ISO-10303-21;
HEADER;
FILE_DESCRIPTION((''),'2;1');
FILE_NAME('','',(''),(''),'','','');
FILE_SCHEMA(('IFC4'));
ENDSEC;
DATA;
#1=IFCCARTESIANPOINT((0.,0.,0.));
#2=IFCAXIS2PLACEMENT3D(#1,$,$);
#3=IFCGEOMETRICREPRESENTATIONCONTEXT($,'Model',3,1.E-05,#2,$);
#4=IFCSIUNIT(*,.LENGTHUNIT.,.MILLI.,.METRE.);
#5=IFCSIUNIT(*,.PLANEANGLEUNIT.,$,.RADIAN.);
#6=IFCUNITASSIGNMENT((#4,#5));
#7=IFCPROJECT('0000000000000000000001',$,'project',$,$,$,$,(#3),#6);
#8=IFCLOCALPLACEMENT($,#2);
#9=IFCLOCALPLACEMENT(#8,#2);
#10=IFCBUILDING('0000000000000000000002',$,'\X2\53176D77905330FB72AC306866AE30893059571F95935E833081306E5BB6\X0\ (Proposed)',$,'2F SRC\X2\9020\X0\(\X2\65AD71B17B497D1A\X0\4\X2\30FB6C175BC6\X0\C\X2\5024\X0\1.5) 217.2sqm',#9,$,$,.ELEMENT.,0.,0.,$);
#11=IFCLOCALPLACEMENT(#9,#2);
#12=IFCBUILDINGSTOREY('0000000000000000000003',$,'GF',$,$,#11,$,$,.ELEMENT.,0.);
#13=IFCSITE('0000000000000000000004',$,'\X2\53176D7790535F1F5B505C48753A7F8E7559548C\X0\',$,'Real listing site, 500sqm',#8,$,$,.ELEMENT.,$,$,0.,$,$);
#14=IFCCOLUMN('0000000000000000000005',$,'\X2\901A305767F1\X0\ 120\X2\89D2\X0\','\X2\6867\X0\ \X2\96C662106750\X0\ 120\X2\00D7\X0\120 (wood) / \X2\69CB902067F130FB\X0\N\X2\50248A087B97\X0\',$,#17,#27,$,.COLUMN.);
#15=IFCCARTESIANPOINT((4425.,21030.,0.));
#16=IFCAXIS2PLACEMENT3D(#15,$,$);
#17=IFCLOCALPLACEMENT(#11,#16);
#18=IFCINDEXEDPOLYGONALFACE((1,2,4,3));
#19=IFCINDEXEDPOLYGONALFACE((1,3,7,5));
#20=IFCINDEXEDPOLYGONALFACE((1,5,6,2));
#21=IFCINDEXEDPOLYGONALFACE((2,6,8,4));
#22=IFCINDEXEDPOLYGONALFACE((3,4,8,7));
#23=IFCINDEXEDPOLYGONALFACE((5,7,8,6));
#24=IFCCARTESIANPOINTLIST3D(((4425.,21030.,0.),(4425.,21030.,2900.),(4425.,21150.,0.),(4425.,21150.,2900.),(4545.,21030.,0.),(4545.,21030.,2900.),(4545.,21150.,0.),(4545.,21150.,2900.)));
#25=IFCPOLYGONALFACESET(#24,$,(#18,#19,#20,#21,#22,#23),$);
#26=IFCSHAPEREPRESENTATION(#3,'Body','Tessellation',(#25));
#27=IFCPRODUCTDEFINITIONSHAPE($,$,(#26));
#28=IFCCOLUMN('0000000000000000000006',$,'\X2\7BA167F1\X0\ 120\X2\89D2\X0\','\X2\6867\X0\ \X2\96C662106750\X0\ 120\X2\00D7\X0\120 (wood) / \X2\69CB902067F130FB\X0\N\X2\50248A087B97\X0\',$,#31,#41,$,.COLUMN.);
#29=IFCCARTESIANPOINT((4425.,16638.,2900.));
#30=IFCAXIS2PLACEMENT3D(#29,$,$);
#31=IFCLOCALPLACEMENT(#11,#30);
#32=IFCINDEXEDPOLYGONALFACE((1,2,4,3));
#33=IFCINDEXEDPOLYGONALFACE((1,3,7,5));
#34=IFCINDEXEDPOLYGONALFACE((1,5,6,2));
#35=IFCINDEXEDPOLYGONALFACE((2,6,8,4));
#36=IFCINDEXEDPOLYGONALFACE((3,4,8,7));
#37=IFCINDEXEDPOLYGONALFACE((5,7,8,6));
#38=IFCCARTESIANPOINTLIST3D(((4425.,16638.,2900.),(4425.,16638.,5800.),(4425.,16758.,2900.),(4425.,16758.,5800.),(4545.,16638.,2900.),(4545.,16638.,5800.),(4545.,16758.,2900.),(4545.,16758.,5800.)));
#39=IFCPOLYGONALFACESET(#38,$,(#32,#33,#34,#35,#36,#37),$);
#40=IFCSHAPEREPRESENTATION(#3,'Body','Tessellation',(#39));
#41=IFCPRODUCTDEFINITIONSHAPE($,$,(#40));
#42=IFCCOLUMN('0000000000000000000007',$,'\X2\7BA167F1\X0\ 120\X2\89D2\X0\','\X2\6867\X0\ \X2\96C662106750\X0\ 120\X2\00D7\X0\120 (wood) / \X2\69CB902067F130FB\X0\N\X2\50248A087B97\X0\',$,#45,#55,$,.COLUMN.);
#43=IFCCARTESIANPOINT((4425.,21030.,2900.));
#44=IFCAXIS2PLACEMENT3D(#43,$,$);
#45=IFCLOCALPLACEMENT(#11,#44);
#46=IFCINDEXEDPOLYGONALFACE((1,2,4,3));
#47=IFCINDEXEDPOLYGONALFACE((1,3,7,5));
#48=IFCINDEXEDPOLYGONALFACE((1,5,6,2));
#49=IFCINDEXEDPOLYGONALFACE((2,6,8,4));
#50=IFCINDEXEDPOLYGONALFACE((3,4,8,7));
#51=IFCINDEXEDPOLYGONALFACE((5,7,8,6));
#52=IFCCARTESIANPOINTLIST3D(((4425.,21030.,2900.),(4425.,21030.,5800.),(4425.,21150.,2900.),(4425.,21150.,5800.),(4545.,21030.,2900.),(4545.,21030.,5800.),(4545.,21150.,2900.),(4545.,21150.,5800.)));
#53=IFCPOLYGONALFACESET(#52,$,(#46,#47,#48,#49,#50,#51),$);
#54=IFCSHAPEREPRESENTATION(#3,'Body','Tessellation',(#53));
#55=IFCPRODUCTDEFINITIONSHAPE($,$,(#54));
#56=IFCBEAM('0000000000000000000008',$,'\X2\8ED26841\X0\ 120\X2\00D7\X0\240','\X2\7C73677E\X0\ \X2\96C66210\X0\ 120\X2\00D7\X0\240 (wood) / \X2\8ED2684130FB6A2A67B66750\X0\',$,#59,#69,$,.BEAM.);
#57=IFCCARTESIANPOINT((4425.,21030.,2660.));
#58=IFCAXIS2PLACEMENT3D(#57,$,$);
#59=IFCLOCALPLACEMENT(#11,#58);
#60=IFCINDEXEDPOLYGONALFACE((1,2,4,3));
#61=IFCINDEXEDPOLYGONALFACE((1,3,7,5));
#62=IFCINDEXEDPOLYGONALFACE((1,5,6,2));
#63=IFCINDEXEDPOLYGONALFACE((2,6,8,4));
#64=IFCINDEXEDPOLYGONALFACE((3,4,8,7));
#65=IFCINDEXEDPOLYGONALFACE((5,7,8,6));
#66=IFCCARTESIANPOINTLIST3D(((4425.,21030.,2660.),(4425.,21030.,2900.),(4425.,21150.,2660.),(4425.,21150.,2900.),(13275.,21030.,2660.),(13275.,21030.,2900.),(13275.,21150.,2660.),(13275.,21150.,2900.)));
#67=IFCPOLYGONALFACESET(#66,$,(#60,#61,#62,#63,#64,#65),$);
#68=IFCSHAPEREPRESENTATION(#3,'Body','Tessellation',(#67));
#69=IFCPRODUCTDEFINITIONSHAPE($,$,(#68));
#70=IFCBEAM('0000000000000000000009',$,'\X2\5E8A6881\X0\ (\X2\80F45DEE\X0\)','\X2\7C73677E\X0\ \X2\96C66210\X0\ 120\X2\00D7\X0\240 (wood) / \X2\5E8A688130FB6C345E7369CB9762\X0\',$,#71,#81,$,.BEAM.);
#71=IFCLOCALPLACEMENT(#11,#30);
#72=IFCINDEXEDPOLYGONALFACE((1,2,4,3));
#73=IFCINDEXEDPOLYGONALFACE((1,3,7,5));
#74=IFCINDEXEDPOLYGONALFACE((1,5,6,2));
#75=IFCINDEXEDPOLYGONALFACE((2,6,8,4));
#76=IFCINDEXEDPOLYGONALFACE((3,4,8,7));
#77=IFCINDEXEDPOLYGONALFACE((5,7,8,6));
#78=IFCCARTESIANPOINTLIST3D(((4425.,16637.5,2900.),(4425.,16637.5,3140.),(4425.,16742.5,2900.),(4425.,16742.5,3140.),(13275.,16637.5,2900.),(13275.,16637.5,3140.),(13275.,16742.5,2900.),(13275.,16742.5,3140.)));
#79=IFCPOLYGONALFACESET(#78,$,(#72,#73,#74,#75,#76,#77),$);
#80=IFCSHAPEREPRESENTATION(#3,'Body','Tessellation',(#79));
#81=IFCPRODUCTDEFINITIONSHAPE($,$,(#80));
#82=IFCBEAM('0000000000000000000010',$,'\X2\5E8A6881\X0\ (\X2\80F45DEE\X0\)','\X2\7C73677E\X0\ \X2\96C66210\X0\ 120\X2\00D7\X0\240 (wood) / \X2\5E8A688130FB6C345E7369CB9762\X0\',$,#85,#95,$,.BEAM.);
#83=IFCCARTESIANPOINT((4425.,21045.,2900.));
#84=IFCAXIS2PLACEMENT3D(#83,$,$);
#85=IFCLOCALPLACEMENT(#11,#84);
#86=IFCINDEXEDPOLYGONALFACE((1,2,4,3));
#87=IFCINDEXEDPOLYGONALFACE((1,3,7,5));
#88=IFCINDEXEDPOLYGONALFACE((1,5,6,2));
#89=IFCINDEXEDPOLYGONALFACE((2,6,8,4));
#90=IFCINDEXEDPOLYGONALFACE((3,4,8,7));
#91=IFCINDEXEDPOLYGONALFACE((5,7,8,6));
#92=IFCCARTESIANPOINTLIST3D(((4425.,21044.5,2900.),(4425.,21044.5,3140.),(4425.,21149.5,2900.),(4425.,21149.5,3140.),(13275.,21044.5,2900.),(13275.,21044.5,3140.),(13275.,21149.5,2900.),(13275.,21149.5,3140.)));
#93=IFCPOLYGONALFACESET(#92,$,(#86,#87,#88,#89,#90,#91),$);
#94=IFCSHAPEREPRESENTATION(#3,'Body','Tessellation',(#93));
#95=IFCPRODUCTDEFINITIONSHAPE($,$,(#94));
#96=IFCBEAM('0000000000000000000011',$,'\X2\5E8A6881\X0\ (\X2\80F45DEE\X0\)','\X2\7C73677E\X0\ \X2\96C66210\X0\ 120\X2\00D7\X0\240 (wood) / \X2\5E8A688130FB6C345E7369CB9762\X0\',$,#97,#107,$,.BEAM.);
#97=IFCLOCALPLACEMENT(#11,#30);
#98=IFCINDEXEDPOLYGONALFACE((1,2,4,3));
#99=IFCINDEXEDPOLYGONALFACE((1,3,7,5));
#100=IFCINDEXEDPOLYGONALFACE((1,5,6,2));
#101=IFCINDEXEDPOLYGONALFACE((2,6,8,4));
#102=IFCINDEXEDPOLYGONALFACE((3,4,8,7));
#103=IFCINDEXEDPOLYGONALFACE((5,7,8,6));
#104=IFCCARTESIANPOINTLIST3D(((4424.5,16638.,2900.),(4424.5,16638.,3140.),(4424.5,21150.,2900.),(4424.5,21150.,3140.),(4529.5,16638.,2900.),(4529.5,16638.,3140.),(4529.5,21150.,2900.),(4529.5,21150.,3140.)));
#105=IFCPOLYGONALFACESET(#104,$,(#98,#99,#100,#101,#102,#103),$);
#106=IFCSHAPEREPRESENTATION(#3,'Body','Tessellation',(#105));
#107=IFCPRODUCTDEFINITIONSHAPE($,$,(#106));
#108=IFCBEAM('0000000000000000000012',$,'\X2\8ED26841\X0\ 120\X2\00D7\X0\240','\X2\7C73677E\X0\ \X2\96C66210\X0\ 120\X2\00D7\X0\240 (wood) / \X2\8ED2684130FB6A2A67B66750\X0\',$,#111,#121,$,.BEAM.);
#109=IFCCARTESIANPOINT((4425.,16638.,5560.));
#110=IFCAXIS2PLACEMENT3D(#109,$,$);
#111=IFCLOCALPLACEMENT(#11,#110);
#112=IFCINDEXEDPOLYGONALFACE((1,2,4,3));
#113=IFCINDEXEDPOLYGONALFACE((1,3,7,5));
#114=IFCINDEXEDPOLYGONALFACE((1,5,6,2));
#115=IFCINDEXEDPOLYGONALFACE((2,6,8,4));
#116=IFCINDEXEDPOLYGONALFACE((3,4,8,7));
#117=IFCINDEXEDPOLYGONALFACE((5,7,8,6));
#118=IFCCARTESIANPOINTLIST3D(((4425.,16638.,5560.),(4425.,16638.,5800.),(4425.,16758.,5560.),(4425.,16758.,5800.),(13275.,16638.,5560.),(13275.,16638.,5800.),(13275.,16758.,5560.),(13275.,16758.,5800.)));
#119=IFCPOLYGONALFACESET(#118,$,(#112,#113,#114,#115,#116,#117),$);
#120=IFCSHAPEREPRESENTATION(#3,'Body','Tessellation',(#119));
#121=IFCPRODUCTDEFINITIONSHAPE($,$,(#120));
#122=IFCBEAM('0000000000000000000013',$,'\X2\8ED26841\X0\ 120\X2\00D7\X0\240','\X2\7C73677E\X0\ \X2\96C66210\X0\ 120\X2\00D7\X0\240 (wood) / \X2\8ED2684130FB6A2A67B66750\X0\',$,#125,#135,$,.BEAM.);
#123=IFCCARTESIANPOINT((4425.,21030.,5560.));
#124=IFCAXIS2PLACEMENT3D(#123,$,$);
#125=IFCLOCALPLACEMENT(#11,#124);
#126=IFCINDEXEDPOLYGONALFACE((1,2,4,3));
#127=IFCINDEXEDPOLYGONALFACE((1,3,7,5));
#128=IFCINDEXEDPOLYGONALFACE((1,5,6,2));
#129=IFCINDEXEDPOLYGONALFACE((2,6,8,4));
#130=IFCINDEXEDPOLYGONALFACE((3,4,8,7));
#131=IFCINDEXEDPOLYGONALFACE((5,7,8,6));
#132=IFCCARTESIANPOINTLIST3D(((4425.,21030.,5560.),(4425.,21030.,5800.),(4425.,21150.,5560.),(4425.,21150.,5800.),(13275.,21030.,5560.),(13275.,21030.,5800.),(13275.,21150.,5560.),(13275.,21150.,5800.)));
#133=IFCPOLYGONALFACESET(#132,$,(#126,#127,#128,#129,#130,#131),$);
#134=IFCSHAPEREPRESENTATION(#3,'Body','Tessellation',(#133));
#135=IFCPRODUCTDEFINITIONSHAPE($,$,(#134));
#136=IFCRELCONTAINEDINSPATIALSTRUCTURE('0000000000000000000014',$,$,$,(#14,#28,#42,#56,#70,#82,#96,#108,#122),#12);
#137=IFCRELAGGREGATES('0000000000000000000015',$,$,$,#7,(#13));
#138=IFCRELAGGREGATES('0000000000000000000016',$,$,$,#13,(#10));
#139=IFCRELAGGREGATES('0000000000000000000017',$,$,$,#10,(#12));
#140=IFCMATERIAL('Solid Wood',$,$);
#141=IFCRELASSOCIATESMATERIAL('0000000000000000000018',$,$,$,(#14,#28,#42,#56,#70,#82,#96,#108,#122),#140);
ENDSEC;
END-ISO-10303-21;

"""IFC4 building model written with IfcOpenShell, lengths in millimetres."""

from ifc_helpers import new_model, si_unit, frame, frame_2d, origin, place, context, project, spatial, rectangle, extrude, material, element, save


model = new_model("IFC4")

# Units and contexts
model_context = context("Model", 3, precision=1e-05, world=origin())
ifc_project = project(units=[si_unit("LENGTHUNIT", "METRE", prefix="MILLI"), si_unit("PLANEANGLEUNIT", "RADIAN")], contexts=[model_context])

# Site, building, storey
site_placement = place(None, origin())
site = spatial("IfcSite", under=ifc_project, at=site_placement, Name="北海道弟子屈町美留和", ObjectType="Real listing site, 500sqm", CompositionType="ELEMENT", RefElevation=0.0)
building_placement = place(site_placement, origin())
building = spatial("IfcBuilding", under=site, at=building_placement, Name="北海道・犬と暮らす土間広めの家 (Proposed)", ObjectType="2F SRC造(断熱等級4・気密C値1.5) 217.2sqm", CompositionType="ELEMENT", ElevationOfRefHeight=0.0, ElevationOfTerrain=0.0)
storey_placement = place(building_placement, origin())
storey = spatial("IfcBuildingStorey", under=building, at=storey_placement, Name="GF", CompositionType="ELEMENT", Elevation=0.0)

# Columns
ifc_material_1 = material(Name="Solid Wood")
column_1_placement = place(storey_placement, frame((4425.0, 21030.0, 0.0)))
element("IfcColumn", 1, at=column_1_placement, inside=storey, material=ifc_material_1, Name="通し柱 120角", Description="桧 集成材 120×120 (wood) / 構造柱・N値計算", PredefinedType="COLUMN", context=model_context, shape_type="SweptSolid", body=[
    extrude(rectangle(XDim=120.0, YDim=120.0, at=frame_2d((60.0, 60.0))), frame((4425.0, 21030.0, 0.0)), (0.0, 0.0, 1.0), 2900.0),
])
column_2_placement = place(storey_placement, frame((4425.0, 16638.0, 2900.0)))
element("IfcColumn", 2, at=column_2_placement, inside=storey, material=ifc_material_1, Name="管柱 120角", Description="桧 集成材 120×120 (wood) / 構造柱・N値計算", PredefinedType="COLUMN", context=model_context, shape_type="SweptSolid", body=[
    extrude(rectangle(XDim=120.0, YDim=120.0, at=frame_2d((60.0, 60.0))), frame((4425.0, 16638.0, 2900.0)), (0.0, 0.0, 1.0), 2900.0),
])
column_3_placement = place(storey_placement, frame((4425.0, 21030.0, 2900.0)))
element("IfcColumn", 3, at=column_3_placement, inside=storey, material=ifc_material_1, Name="管柱 120角", Description="桧 集成材 120×120 (wood) / 構造柱・N値計算", PredefinedType="COLUMN", context=model_context, shape_type="SweptSolid", body=[
    extrude(rectangle(XDim=120.0, YDim=120.0, at=frame_2d((60.0, 60.0))), frame((4425.0, 21030.0, 2900.0)), (0.0, 0.0, 1.0), 2900.0),
])

# Beams
beam_1_placement = place(storey_placement, frame((4425.0, 21030.0, 2660.0)))
element("IfcBeam", 4, at=beam_1_placement, inside=storey, material=ifc_material_1, Name="軒桁 120×240", Description="米松 集成 120×240 (wood) / 軒桁・横架材", PredefinedType="BEAM", context=model_context, shape_type="SweptSolid", body=[
    extrude(rectangle(XDim=8850.0, YDim=120.0, at=frame_2d((4425.0, 60.0))), frame((4425.0, 21030.0, 2660.0)), (0.0, 0.0, 1.0), 240.0),
])
beam_2_placement = place(storey_placement, frame((4425.0, 16638.0, 2900.0)))
element("IfcBeam", 5, at=beam_2_placement, inside=storey, material=ifc_material_1, Name="床梁 (胴差)", Description="米松 集成 120×240 (wood) / 床梁・水平構面", PredefinedType="BEAM", context=model_context, shape_type="SweptSolid", body=[
    extrude(rectangle(XDim=8850.0, YDim=105.0, at=frame_2d((4425.0, 52.0))), frame((4425.0, 16638.0, 2900.0)), (0.0, 0.0, 1.0), 240.0),
])
beam_3_placement = place(storey_placement, frame((4425.0, 21045.0, 2900.0)))
element("IfcBeam", 6, at=beam_3_placement, inside=storey, material=ifc_material_1, Name="床梁 (胴差)", Description="米松 集成 120×240 (wood) / 床梁・水平構面", PredefinedType="BEAM", context=model_context, shape_type="SweptSolid", body=[
    extrude(rectangle(XDim=8850.0, YDim=105.0, at=frame_2d((4425.0, 52.0))), frame((4425.0, 21045.0, 2900.0)), (0.0, 0.0, 1.0), 240.0),
])
beam_4_placement = place(storey_placement, frame((4425.0, 16638.0, 2900.0)))
element("IfcBeam", 7, at=beam_4_placement, inside=storey, material=ifc_material_1, Name="床梁 (胴差)", Description="米松 集成 120×240 (wood) / 床梁・水平構面", PredefinedType="BEAM", context=model_context, shape_type="SweptSolid", body=[
    extrude(rectangle(XDim=105.0, YDim=4512.0, at=frame_2d((52.0, 2256.0))), frame((4425.0, 16638.0, 2900.0)), (0.0, 0.0, 1.0), 240.0),
])
beam_5_placement = place(storey_placement, frame((4425.0, 16638.0, 5560.0)))
element("IfcBeam", 8, at=beam_5_placement, inside=storey, material=ifc_material_1, Name="軒桁 120×240", Description="米松 集成 120×240 (wood) / 軒桁・横架材", PredefinedType="BEAM", context=model_context, shape_type="SweptSolid", body=[
    extrude(rectangle(XDim=8850.0, YDim=120.0, at=frame_2d((4425.0, 60.0))), frame((4425.0, 16638.0, 5560.0)), (0.0, 0.0, 1.0), 240.0),
])
beam_6_placement = place(storey_placement, frame((4425.0, 21030.0, 5560.0)))
element("IfcBeam", 9, at=beam_6_placement, inside=storey, material=ifc_material_1, Name="軒桁 120×240", Description="米松 集成 120×240 (wood) / 軒桁・横架材", PredefinedType="BEAM", context=model_context, shape_type="SweptSolid", body=[
    extrude(rectangle(XDim=8850.0, YDim=120.0, at=frame_2d((4425.0, 60.0))), frame((4425.0, 21030.0, 5560.0)), (0.0, 0.0, 1.0), 240.0),
])

save(model, "model.ifc")
